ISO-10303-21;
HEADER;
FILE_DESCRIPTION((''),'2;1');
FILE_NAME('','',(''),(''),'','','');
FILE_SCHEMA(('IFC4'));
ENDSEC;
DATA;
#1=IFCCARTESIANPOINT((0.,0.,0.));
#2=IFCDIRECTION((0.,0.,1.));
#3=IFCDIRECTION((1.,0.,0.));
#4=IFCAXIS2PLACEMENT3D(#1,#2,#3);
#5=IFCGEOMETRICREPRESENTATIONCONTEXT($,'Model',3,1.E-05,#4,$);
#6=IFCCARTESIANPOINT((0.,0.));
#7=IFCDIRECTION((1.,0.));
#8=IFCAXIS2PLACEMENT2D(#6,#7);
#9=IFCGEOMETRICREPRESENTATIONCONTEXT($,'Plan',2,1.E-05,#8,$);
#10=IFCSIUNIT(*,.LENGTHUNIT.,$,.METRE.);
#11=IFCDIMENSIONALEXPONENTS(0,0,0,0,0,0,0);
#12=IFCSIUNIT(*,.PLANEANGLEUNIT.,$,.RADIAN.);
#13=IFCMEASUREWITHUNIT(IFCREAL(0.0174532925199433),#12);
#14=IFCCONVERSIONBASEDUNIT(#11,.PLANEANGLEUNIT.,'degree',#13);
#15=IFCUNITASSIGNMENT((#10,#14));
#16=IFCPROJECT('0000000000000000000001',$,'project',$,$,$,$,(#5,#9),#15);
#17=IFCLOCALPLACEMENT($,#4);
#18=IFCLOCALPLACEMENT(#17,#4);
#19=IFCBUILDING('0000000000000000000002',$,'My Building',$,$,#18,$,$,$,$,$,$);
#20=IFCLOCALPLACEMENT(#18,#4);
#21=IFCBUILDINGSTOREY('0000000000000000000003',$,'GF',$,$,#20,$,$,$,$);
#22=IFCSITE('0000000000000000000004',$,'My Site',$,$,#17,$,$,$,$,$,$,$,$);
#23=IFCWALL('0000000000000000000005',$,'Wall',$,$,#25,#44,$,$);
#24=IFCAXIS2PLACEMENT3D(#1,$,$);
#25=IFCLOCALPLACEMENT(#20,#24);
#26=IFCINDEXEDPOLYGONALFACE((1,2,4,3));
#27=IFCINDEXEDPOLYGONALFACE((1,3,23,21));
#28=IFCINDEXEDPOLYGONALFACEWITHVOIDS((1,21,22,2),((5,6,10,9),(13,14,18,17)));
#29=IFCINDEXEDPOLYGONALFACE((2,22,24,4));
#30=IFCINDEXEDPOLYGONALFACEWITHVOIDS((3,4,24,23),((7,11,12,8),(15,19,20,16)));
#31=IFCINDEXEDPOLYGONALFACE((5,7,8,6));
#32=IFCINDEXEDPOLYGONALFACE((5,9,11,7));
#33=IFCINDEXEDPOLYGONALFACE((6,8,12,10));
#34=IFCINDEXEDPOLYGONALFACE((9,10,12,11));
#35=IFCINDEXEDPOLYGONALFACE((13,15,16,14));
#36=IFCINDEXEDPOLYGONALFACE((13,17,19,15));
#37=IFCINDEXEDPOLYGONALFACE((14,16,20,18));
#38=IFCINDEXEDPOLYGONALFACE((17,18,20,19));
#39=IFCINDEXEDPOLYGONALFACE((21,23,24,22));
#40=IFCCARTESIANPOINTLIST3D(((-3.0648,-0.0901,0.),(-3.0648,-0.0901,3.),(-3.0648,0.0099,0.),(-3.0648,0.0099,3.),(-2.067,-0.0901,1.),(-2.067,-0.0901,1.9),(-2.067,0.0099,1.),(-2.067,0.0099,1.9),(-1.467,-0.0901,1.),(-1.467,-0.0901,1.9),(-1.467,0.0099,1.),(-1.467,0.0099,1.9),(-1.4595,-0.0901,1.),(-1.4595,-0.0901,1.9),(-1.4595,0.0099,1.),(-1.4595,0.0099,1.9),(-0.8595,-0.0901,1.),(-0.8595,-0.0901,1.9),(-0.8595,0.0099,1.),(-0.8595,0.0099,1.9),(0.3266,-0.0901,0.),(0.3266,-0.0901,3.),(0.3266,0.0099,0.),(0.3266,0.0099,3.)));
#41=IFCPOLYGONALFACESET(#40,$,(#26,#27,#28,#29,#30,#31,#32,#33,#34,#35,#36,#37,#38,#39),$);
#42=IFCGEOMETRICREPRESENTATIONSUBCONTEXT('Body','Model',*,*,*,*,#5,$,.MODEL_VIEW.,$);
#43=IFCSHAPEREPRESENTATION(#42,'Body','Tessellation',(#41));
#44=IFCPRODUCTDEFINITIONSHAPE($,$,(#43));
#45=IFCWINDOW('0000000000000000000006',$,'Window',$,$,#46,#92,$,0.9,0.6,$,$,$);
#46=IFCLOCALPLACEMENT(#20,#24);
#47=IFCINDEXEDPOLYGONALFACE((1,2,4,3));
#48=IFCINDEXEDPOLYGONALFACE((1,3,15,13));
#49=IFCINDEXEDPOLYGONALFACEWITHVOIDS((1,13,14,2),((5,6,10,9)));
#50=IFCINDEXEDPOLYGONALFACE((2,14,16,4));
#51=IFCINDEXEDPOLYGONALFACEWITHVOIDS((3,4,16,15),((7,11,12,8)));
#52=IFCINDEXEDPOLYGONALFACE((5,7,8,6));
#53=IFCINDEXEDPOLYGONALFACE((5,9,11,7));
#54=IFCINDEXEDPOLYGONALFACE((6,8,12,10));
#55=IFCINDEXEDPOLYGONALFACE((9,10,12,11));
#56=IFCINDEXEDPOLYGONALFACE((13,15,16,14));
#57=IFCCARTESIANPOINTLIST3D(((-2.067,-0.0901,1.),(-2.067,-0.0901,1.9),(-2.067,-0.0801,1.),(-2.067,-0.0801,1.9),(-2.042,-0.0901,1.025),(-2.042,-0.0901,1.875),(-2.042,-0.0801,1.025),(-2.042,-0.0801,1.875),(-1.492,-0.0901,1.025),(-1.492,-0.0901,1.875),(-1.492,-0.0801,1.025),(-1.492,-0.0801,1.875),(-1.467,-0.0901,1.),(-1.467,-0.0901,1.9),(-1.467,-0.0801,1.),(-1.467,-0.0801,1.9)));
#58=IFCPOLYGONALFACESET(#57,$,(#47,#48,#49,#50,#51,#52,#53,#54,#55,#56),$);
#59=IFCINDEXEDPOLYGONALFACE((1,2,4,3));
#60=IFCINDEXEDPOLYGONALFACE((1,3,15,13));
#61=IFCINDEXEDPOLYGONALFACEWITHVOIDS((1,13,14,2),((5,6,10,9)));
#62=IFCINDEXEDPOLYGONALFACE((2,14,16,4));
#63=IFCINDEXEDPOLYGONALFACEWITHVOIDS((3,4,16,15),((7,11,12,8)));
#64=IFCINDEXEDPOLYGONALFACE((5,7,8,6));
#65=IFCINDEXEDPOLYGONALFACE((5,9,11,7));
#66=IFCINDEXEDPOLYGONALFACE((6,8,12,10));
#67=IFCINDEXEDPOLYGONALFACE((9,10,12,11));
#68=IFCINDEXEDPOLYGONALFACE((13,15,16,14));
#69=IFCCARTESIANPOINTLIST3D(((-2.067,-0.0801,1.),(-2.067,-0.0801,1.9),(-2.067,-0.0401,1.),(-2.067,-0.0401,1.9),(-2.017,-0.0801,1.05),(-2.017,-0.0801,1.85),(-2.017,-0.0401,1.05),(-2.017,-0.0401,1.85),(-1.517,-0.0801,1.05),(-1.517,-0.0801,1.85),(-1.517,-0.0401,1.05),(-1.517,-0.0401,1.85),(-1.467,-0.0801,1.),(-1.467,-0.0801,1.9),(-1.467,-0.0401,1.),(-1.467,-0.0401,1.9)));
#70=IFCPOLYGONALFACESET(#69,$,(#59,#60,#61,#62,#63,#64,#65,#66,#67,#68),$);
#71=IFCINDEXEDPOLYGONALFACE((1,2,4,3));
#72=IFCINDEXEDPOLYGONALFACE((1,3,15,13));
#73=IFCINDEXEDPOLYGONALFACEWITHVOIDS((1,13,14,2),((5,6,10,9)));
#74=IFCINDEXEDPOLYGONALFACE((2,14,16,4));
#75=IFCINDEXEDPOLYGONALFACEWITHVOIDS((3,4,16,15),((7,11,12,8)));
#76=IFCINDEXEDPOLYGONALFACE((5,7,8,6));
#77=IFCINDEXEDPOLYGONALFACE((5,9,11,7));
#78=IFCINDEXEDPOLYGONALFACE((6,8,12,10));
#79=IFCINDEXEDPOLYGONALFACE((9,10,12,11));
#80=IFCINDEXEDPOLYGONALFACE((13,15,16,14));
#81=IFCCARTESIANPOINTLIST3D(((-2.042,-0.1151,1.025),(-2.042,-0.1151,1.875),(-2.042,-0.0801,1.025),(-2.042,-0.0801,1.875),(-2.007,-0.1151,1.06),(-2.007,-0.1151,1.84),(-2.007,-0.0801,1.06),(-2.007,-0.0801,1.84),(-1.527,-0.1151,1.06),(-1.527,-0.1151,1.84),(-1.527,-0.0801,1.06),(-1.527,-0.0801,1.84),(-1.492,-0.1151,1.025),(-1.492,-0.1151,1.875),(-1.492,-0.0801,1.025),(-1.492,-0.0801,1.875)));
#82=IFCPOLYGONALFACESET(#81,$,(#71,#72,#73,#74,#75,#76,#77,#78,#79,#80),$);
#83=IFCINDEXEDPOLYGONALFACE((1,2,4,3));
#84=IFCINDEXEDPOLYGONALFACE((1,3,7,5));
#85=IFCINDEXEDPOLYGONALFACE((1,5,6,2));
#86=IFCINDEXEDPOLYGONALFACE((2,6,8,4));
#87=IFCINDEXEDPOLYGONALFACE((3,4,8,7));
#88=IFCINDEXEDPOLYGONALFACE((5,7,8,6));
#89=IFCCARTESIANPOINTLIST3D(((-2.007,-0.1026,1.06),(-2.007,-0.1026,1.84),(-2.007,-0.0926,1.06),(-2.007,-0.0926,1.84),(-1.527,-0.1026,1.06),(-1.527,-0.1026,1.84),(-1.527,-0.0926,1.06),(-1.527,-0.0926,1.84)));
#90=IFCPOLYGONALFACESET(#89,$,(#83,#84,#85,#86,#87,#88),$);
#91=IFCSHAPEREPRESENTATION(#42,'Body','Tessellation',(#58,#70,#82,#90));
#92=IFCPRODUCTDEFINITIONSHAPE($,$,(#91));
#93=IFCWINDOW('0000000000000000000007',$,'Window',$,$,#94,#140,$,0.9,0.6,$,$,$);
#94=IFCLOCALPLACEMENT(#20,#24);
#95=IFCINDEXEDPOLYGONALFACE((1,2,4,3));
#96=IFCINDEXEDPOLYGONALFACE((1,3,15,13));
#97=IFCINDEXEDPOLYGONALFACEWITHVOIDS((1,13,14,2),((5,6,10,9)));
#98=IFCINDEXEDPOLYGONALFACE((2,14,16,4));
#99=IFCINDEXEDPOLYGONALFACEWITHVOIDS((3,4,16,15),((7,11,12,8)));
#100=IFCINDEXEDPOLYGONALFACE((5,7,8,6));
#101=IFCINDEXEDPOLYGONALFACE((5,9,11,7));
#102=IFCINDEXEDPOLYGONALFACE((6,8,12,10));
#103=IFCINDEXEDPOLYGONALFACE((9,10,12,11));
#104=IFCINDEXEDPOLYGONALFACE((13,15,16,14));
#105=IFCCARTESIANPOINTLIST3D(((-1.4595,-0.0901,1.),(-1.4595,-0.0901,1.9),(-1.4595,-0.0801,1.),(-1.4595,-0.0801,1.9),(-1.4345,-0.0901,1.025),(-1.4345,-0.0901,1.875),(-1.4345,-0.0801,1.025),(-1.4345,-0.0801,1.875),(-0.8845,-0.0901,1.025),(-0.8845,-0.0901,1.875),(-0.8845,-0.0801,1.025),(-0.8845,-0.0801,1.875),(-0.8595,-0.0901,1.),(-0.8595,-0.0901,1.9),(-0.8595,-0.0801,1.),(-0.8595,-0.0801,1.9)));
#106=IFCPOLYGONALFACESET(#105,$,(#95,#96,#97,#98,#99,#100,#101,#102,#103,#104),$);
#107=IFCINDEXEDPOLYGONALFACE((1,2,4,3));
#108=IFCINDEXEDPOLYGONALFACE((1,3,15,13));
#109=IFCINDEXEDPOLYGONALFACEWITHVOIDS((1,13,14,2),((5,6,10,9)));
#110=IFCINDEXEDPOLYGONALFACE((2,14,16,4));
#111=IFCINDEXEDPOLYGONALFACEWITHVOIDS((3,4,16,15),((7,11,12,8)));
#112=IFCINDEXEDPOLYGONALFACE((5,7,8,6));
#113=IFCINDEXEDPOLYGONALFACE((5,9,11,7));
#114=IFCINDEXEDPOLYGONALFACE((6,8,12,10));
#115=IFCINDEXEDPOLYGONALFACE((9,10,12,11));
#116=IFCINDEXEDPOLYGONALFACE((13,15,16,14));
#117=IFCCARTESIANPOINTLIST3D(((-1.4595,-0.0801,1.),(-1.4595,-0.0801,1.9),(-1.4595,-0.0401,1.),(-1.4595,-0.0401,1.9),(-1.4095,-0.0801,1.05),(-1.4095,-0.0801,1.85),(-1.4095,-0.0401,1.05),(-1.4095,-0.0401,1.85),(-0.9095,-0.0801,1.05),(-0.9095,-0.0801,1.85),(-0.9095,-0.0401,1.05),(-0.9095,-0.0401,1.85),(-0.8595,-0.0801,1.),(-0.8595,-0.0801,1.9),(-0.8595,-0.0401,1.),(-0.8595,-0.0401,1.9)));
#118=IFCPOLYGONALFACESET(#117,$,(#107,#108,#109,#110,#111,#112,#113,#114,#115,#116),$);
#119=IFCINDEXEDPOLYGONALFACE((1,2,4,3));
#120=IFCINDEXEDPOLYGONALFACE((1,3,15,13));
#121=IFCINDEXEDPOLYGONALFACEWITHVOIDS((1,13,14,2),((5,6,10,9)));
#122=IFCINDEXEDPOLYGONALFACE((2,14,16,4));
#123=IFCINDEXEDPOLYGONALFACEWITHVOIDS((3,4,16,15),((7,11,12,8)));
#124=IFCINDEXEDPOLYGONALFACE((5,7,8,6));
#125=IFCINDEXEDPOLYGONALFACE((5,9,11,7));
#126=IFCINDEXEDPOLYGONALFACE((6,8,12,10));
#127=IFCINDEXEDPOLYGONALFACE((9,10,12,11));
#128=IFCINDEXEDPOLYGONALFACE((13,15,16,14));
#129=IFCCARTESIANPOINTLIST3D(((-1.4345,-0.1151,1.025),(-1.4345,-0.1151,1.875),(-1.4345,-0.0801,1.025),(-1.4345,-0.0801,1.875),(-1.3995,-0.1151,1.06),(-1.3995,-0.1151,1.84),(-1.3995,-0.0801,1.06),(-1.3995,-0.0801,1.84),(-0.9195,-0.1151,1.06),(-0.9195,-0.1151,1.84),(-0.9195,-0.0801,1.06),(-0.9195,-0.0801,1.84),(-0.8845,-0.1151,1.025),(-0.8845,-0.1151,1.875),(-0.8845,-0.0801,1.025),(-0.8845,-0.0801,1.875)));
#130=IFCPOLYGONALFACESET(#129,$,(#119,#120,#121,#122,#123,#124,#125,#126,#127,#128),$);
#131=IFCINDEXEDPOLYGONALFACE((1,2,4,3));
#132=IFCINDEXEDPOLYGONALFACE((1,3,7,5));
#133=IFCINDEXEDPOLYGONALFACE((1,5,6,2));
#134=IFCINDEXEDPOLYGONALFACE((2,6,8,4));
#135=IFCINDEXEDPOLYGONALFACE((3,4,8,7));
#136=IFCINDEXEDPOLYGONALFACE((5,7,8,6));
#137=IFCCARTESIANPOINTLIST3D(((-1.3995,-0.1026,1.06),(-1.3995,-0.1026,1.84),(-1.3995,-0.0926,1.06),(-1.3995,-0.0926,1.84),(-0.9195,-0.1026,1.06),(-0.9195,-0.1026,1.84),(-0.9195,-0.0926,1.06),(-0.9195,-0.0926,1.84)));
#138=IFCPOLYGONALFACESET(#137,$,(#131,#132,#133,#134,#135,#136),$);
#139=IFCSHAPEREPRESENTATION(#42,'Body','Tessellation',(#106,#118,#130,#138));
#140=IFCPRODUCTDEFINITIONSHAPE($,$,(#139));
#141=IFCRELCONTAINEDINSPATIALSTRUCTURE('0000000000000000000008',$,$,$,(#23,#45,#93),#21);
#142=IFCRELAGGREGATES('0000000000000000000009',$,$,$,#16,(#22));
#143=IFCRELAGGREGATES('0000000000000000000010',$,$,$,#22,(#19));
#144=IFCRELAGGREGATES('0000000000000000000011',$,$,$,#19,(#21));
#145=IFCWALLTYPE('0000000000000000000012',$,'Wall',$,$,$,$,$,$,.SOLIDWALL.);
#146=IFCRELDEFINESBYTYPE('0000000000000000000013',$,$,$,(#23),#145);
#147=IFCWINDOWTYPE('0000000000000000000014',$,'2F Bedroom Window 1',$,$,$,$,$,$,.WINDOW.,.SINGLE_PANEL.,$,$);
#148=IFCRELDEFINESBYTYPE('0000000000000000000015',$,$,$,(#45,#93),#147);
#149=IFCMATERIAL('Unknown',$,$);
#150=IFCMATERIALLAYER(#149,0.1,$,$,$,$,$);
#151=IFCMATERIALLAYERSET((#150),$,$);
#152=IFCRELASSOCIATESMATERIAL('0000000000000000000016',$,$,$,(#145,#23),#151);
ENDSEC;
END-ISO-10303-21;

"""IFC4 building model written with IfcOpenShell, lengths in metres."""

from ifc_helpers import new_model, entity, si_unit, converted_unit, frame, origin_with_axes, origin_2d_with_axis, place, context, subcontext, project, spatial, line, indexed_curve, outline, extrude, shape, source, transform, mapped, material, layer, layer_set, layer_usage, type_object, type_shapes, element, fill, save


model = new_model("IFC4")

# Units and contexts
model_context = context("Model", 3, precision=1e-05, world=origin_with_axes())
plan_context = context("Plan", 2, precision=1e-05, world=origin_2d_with_axis())
body_context_1 = subcontext(model_context, "Body", "Model", "MODEL_VIEW")
body_context_2 = subcontext(plan_context, "Body", "Plan", "PLAN_VIEW")
ifc_project = project(units=[si_unit("LENGTHUNIT", "METRE"), converted_unit("PLANEANGLEUNIT", "degree", entity("IfcReal", 0.0174532925199433), si_unit("PLANEANGLEUNIT", "RADIAN"), dimensions=[0, 0, 0, 0, 0, 0, 0])], contexts=[model_context, plan_context])

# Site, building, storey
site_placement = place(None, origin_with_axes())
site = spatial("IfcSite", under=ifc_project, at=site_placement, Name="My Site")
building_placement = place(site_placement, origin_with_axes())
building = spatial("IfcBuilding", under=site, at=building_placement, Name="My Building")
storey_placement = place(building_placement, origin_with_axes())
storey = spatial("IfcBuildingStorey", under=building, at=storey_placement, Name="GF")

# Shared definitions
ifc_material_1 = material(Name="Unknown")

# Shared definitions
ifc_layer_1 = layer(ifc_material_1, 0.1)
ifc_layer_set_1 = layer_set([ifc_layer_1])
wall_type = type_object("IfcWallType", Name="Wall", PredefinedType="SOLIDWALL", material=ifc_layer_set_1)

# Shared definitions
shared_shape_1 = source(origin_with_axes(), body_context_1, "Body", "SweptSolid", [
    extrude(outline(indexed_curve([(0.0, 0.0), (0.6, 0.0), (0.6, 0.9), (0.0, 0.9)], segments=[line(1, 2, 3, 4, 1)])), frame((0.0, -0.6, 0.0), z_axis=(0.0, -1.0, 0.0), x_axis=(1.0, 0.0, 0.0)), (0.0, 0.0, -1.0), 1.2),
])
window_type_1 = type_object("IfcWindowType", Name="2F Bedroom Window 1", PartitioningType="SINGLE_PANEL", PredefinedType="WINDOW")
shared_shape_2 = source(origin_with_axes(), body_context_1, "Body", "SweptSolid", [
    extrude(outline(indexed_curve([(0.0, 0.0), (0.6, 0.0), (0.6, 0.9), (0.0, 0.9)], segments=[line(1, 2, 3, 4, 1)]), holes=[indexed_curve([(0.025, 0.025), (0.575, 0.025), (0.575, 0.875), (0.025, 0.875)], segments=[line(1, 2, 3, 4, 1)])]), frame((0.0, 0.09, 0.0), z_axis=(0.0, -1.0, 0.0), x_axis=(1.0, 0.0, 0.0)), (0.0, 0.0, -1.0), 0.01),
    extrude(outline(indexed_curve([(0.0, 0.0), (0.6, 0.0), (0.6, 0.9), (0.0, 0.9)], segments=[line(1, 2, 3, 4, 1)]), holes=[indexed_curve([(0.05, 0.05), (0.55, 0.05), (0.55, 0.85), (0.05, 0.85)], segments=[line(1, 2, 3, 4, 1)])]), frame((0.0, 0.05, 0.0), z_axis=(0.0, -1.0, 0.0), x_axis=(1.0, 0.0, 0.0)), (0.0, 0.0, -1.0), 0.04),
    extrude(outline(indexed_curve([(0.0, 0.0), (0.55, 0.0), (0.55, 0.85), (0.0, 0.85)], segments=[line(1, 2, 3, 4, 1)]), holes=[indexed_curve([(0.035, 0.035), (0.515, 0.035), (0.515, 0.815), (0.035, 0.815)], segments=[line(1, 2, 3, 4, 1)])]), frame((0.025, 0.09, 0.025), z_axis=(0.0, -1.0, 0.0), x_axis=(1.0, 0.0, 0.0)), (0.0, 0.0, -1.0), 0.035),
    extrude(outline(indexed_curve([(0.035, 0.035), (0.515, 0.035), (0.515, 0.815), (0.035, 0.815)], segments=[line(1, 2, 3, 4, 1)])), frame((0.025, 0.1025, 0.025), z_axis=(0.0, -1.0, 0.0), x_axis=(1.0, 0.0, 0.0)), (0.0, 0.0, -1.0), 0.01),
])
shared_shape_3 = source(origin_with_axes(), body_context_2, "Body", "Curve2D", [
    entity("IfcIndexedPolyCurve", entity("IfcCartesianPointList2D", [[0.05, 0.05], [0.55, 0.05]])),
    entity("IfcIndexedPolyCurve", entity("IfcCartesianPointList2D", [[0.0, 0.1], [0.025, 0.1], [0.025, 0.09], [0.05, 0.09], [0.05, 0.05], [0.0, 0.05]]), [entity("IfcLineIndex", [1, 2, 3, 4, 5, 6, 1])]),
    entity("IfcIndexedPolyCurve", entity("IfcCartesianPointList2D", [[0.6, 0.1], [0.575, 0.1], [0.575, 0.09], [0.55, 0.09], [0.55, 0.05], [0.6, 0.05]]), [entity("IfcLineIndex", [1, 2, 3, 4, 5, 6, 1])]),
    entity("IfcIndexedPolyCurve", entity("IfcCartesianPointList2D", [[0.025, 0.09], [0.06, 0.09], [0.06, 0.125], [0.025, 0.125]]), [entity("IfcLineIndex", [1, 2, 3, 4, 1])]),
    entity("IfcIndexedPolyCurve", entity("IfcCartesianPointList2D", [[0.575, 0.09], [0.54, 0.09], [0.54, 0.125], [0.575, 0.125]]), [entity("IfcLineIndex", [1, 2, 3, 4, 1])]),
    entity("IfcIndexedPolyCurve", entity("IfcCartesianPointList2D", [[0.06, 0.09], [0.54, 0.09]])),
    entity("IfcIndexedPolyCurve", entity("IfcCartesianPointList2D", [[0.06, 0.125], [0.54, 0.125]])),
    entity("IfcIndexedPolyCurve", entity("IfcCartesianPointList2D", [[0.06, 0.1075], [0.54, 0.1075]])),
])
type_shapes(window_type_1, [shared_shape_2, shared_shape_3])

# Wall, openings, windows
ifc_layer_usage_1 = layer_usage(ifc_layer_set_1, "AXIS2", "POSITIVE", 0.0)
wall_1_placement = place(storey_placement, frame((0.3266, 0.0099, 0.0), z_axis=(0.0, 0.0, 1.0), x_axis=(-1.0, 0.0, 0.0)))
wall_1 = element("IfcWall", 1, at=wall_1_placement, inside=storey, type_object=wall_type, material=ifc_layer_usage_1, Name="Wall", context=body_context_1, shape_type="SweptSolid", body=[
    extrude(outline(indexed_curve([(0.0, 0.0), (0.0, 0.1), (3.3914, 0.1), (3.3914, 0.0)], segments=[line(1, 2, 3, 4, 1)])), origin_with_axes(), (0.0, 0.0, 1.0), 3.0),
])
opening_1_placement = place(wall_1_placement, frame((1.7936, 0.0, 1.0), z_axis=(0.0, 0.0, 1.0), x_axis=(1.0, 0.0, 0.0)))
opening_1 = element("IfcOpeningElement", 2, at=opening_1_placement, cuts=wall_1, PredefinedType="OPENING", context=body_context_1, shape_type="MappedRepresentation", body=[
    mapped(shared_shape_1, transform((0.0, 0.0, 0.0), x_axis=(1.0, 0.0, 0.0), y_axis=(0.0, 1.0, 0.0), z_axis=(0.0, 0.0, 1.0), scale=1.0)),
])
opening_2_placement = place(wall_1_placement, frame((1.1861, 0.0, 1.0), z_axis=(0.0, 0.0, 1.0), x_axis=(1.0, 0.0, 0.0)))
opening_2 = element("IfcOpeningElement", 3, at=opening_2_placement, cuts=wall_1, PredefinedType="OPENING", context=body_context_1, shape_type="MappedRepresentation", body=[
    mapped(shared_shape_1, transform((0.0, 0.0, 0.0), x_axis=(1.0, 0.0, 0.0), y_axis=(0.0, 1.0, 0.0), z_axis=(0.0, 0.0, 1.0), scale=1.0)),
])
window_1_placement = place(opening_1_placement, frame((0.0, 0.0, 0.0), z_axis=(0.0, 0.0, 1.0), x_axis=(1.0, 0.0, 0.0)))
window_1 = element("IfcWindow", 4, at=window_1_placement, inside=storey, type_object=window_type_1, Name="Window", OverallHeight=0.9, OverallWidth=0.6, shapes=[
    shape(body_context_1, "Body", "MappedRepresentation", [mapped(shared_shape_2, transform((0.0, 0.0, 0.0), x_axis=(1.0, 0.0, 0.0), y_axis=(0.0, 1.0, 0.0), z_axis=(0.0, 0.0, 1.0), scale=1.0))]),
    shape(body_context_2, "Body", "MappedRepresentation", [mapped(shared_shape_3, transform((0.0, 0.0, 0.0), x_axis=(1.0, 0.0, 0.0), y_axis=(0.0, 1.0, 0.0), z_axis=(0.0, 0.0, 1.0), scale=1.0))]),
])
fill(opening_1, window_1)
window_2_placement = place(opening_2_placement, origin_with_axes())
window_2 = element("IfcWindow", 5, at=window_2_placement, inside=storey, type_object=window_type_1, Name="Window", OverallHeight=0.9, OverallWidth=0.6, shapes=[
    shape(body_context_1, "Body", "MappedRepresentation", [mapped(shared_shape_2, transform((0.0, 0.0, 0.0), x_axis=(1.0, 0.0, 0.0), y_axis=(0.0, 1.0, 0.0), z_axis=(0.0, 0.0, 1.0), scale=1.0))]),
    shape(body_context_2, "Body", "MappedRepresentation", [mapped(shared_shape_3, transform((0.0, 0.0, 0.0), x_axis=(1.0, 0.0, 0.0), y_axis=(0.0, 1.0, 0.0), z_axis=(0.0, 0.0, 1.0), scale=1.0))]),
])
fill(opening_2, window_2)

save(model, "model.ifc")
